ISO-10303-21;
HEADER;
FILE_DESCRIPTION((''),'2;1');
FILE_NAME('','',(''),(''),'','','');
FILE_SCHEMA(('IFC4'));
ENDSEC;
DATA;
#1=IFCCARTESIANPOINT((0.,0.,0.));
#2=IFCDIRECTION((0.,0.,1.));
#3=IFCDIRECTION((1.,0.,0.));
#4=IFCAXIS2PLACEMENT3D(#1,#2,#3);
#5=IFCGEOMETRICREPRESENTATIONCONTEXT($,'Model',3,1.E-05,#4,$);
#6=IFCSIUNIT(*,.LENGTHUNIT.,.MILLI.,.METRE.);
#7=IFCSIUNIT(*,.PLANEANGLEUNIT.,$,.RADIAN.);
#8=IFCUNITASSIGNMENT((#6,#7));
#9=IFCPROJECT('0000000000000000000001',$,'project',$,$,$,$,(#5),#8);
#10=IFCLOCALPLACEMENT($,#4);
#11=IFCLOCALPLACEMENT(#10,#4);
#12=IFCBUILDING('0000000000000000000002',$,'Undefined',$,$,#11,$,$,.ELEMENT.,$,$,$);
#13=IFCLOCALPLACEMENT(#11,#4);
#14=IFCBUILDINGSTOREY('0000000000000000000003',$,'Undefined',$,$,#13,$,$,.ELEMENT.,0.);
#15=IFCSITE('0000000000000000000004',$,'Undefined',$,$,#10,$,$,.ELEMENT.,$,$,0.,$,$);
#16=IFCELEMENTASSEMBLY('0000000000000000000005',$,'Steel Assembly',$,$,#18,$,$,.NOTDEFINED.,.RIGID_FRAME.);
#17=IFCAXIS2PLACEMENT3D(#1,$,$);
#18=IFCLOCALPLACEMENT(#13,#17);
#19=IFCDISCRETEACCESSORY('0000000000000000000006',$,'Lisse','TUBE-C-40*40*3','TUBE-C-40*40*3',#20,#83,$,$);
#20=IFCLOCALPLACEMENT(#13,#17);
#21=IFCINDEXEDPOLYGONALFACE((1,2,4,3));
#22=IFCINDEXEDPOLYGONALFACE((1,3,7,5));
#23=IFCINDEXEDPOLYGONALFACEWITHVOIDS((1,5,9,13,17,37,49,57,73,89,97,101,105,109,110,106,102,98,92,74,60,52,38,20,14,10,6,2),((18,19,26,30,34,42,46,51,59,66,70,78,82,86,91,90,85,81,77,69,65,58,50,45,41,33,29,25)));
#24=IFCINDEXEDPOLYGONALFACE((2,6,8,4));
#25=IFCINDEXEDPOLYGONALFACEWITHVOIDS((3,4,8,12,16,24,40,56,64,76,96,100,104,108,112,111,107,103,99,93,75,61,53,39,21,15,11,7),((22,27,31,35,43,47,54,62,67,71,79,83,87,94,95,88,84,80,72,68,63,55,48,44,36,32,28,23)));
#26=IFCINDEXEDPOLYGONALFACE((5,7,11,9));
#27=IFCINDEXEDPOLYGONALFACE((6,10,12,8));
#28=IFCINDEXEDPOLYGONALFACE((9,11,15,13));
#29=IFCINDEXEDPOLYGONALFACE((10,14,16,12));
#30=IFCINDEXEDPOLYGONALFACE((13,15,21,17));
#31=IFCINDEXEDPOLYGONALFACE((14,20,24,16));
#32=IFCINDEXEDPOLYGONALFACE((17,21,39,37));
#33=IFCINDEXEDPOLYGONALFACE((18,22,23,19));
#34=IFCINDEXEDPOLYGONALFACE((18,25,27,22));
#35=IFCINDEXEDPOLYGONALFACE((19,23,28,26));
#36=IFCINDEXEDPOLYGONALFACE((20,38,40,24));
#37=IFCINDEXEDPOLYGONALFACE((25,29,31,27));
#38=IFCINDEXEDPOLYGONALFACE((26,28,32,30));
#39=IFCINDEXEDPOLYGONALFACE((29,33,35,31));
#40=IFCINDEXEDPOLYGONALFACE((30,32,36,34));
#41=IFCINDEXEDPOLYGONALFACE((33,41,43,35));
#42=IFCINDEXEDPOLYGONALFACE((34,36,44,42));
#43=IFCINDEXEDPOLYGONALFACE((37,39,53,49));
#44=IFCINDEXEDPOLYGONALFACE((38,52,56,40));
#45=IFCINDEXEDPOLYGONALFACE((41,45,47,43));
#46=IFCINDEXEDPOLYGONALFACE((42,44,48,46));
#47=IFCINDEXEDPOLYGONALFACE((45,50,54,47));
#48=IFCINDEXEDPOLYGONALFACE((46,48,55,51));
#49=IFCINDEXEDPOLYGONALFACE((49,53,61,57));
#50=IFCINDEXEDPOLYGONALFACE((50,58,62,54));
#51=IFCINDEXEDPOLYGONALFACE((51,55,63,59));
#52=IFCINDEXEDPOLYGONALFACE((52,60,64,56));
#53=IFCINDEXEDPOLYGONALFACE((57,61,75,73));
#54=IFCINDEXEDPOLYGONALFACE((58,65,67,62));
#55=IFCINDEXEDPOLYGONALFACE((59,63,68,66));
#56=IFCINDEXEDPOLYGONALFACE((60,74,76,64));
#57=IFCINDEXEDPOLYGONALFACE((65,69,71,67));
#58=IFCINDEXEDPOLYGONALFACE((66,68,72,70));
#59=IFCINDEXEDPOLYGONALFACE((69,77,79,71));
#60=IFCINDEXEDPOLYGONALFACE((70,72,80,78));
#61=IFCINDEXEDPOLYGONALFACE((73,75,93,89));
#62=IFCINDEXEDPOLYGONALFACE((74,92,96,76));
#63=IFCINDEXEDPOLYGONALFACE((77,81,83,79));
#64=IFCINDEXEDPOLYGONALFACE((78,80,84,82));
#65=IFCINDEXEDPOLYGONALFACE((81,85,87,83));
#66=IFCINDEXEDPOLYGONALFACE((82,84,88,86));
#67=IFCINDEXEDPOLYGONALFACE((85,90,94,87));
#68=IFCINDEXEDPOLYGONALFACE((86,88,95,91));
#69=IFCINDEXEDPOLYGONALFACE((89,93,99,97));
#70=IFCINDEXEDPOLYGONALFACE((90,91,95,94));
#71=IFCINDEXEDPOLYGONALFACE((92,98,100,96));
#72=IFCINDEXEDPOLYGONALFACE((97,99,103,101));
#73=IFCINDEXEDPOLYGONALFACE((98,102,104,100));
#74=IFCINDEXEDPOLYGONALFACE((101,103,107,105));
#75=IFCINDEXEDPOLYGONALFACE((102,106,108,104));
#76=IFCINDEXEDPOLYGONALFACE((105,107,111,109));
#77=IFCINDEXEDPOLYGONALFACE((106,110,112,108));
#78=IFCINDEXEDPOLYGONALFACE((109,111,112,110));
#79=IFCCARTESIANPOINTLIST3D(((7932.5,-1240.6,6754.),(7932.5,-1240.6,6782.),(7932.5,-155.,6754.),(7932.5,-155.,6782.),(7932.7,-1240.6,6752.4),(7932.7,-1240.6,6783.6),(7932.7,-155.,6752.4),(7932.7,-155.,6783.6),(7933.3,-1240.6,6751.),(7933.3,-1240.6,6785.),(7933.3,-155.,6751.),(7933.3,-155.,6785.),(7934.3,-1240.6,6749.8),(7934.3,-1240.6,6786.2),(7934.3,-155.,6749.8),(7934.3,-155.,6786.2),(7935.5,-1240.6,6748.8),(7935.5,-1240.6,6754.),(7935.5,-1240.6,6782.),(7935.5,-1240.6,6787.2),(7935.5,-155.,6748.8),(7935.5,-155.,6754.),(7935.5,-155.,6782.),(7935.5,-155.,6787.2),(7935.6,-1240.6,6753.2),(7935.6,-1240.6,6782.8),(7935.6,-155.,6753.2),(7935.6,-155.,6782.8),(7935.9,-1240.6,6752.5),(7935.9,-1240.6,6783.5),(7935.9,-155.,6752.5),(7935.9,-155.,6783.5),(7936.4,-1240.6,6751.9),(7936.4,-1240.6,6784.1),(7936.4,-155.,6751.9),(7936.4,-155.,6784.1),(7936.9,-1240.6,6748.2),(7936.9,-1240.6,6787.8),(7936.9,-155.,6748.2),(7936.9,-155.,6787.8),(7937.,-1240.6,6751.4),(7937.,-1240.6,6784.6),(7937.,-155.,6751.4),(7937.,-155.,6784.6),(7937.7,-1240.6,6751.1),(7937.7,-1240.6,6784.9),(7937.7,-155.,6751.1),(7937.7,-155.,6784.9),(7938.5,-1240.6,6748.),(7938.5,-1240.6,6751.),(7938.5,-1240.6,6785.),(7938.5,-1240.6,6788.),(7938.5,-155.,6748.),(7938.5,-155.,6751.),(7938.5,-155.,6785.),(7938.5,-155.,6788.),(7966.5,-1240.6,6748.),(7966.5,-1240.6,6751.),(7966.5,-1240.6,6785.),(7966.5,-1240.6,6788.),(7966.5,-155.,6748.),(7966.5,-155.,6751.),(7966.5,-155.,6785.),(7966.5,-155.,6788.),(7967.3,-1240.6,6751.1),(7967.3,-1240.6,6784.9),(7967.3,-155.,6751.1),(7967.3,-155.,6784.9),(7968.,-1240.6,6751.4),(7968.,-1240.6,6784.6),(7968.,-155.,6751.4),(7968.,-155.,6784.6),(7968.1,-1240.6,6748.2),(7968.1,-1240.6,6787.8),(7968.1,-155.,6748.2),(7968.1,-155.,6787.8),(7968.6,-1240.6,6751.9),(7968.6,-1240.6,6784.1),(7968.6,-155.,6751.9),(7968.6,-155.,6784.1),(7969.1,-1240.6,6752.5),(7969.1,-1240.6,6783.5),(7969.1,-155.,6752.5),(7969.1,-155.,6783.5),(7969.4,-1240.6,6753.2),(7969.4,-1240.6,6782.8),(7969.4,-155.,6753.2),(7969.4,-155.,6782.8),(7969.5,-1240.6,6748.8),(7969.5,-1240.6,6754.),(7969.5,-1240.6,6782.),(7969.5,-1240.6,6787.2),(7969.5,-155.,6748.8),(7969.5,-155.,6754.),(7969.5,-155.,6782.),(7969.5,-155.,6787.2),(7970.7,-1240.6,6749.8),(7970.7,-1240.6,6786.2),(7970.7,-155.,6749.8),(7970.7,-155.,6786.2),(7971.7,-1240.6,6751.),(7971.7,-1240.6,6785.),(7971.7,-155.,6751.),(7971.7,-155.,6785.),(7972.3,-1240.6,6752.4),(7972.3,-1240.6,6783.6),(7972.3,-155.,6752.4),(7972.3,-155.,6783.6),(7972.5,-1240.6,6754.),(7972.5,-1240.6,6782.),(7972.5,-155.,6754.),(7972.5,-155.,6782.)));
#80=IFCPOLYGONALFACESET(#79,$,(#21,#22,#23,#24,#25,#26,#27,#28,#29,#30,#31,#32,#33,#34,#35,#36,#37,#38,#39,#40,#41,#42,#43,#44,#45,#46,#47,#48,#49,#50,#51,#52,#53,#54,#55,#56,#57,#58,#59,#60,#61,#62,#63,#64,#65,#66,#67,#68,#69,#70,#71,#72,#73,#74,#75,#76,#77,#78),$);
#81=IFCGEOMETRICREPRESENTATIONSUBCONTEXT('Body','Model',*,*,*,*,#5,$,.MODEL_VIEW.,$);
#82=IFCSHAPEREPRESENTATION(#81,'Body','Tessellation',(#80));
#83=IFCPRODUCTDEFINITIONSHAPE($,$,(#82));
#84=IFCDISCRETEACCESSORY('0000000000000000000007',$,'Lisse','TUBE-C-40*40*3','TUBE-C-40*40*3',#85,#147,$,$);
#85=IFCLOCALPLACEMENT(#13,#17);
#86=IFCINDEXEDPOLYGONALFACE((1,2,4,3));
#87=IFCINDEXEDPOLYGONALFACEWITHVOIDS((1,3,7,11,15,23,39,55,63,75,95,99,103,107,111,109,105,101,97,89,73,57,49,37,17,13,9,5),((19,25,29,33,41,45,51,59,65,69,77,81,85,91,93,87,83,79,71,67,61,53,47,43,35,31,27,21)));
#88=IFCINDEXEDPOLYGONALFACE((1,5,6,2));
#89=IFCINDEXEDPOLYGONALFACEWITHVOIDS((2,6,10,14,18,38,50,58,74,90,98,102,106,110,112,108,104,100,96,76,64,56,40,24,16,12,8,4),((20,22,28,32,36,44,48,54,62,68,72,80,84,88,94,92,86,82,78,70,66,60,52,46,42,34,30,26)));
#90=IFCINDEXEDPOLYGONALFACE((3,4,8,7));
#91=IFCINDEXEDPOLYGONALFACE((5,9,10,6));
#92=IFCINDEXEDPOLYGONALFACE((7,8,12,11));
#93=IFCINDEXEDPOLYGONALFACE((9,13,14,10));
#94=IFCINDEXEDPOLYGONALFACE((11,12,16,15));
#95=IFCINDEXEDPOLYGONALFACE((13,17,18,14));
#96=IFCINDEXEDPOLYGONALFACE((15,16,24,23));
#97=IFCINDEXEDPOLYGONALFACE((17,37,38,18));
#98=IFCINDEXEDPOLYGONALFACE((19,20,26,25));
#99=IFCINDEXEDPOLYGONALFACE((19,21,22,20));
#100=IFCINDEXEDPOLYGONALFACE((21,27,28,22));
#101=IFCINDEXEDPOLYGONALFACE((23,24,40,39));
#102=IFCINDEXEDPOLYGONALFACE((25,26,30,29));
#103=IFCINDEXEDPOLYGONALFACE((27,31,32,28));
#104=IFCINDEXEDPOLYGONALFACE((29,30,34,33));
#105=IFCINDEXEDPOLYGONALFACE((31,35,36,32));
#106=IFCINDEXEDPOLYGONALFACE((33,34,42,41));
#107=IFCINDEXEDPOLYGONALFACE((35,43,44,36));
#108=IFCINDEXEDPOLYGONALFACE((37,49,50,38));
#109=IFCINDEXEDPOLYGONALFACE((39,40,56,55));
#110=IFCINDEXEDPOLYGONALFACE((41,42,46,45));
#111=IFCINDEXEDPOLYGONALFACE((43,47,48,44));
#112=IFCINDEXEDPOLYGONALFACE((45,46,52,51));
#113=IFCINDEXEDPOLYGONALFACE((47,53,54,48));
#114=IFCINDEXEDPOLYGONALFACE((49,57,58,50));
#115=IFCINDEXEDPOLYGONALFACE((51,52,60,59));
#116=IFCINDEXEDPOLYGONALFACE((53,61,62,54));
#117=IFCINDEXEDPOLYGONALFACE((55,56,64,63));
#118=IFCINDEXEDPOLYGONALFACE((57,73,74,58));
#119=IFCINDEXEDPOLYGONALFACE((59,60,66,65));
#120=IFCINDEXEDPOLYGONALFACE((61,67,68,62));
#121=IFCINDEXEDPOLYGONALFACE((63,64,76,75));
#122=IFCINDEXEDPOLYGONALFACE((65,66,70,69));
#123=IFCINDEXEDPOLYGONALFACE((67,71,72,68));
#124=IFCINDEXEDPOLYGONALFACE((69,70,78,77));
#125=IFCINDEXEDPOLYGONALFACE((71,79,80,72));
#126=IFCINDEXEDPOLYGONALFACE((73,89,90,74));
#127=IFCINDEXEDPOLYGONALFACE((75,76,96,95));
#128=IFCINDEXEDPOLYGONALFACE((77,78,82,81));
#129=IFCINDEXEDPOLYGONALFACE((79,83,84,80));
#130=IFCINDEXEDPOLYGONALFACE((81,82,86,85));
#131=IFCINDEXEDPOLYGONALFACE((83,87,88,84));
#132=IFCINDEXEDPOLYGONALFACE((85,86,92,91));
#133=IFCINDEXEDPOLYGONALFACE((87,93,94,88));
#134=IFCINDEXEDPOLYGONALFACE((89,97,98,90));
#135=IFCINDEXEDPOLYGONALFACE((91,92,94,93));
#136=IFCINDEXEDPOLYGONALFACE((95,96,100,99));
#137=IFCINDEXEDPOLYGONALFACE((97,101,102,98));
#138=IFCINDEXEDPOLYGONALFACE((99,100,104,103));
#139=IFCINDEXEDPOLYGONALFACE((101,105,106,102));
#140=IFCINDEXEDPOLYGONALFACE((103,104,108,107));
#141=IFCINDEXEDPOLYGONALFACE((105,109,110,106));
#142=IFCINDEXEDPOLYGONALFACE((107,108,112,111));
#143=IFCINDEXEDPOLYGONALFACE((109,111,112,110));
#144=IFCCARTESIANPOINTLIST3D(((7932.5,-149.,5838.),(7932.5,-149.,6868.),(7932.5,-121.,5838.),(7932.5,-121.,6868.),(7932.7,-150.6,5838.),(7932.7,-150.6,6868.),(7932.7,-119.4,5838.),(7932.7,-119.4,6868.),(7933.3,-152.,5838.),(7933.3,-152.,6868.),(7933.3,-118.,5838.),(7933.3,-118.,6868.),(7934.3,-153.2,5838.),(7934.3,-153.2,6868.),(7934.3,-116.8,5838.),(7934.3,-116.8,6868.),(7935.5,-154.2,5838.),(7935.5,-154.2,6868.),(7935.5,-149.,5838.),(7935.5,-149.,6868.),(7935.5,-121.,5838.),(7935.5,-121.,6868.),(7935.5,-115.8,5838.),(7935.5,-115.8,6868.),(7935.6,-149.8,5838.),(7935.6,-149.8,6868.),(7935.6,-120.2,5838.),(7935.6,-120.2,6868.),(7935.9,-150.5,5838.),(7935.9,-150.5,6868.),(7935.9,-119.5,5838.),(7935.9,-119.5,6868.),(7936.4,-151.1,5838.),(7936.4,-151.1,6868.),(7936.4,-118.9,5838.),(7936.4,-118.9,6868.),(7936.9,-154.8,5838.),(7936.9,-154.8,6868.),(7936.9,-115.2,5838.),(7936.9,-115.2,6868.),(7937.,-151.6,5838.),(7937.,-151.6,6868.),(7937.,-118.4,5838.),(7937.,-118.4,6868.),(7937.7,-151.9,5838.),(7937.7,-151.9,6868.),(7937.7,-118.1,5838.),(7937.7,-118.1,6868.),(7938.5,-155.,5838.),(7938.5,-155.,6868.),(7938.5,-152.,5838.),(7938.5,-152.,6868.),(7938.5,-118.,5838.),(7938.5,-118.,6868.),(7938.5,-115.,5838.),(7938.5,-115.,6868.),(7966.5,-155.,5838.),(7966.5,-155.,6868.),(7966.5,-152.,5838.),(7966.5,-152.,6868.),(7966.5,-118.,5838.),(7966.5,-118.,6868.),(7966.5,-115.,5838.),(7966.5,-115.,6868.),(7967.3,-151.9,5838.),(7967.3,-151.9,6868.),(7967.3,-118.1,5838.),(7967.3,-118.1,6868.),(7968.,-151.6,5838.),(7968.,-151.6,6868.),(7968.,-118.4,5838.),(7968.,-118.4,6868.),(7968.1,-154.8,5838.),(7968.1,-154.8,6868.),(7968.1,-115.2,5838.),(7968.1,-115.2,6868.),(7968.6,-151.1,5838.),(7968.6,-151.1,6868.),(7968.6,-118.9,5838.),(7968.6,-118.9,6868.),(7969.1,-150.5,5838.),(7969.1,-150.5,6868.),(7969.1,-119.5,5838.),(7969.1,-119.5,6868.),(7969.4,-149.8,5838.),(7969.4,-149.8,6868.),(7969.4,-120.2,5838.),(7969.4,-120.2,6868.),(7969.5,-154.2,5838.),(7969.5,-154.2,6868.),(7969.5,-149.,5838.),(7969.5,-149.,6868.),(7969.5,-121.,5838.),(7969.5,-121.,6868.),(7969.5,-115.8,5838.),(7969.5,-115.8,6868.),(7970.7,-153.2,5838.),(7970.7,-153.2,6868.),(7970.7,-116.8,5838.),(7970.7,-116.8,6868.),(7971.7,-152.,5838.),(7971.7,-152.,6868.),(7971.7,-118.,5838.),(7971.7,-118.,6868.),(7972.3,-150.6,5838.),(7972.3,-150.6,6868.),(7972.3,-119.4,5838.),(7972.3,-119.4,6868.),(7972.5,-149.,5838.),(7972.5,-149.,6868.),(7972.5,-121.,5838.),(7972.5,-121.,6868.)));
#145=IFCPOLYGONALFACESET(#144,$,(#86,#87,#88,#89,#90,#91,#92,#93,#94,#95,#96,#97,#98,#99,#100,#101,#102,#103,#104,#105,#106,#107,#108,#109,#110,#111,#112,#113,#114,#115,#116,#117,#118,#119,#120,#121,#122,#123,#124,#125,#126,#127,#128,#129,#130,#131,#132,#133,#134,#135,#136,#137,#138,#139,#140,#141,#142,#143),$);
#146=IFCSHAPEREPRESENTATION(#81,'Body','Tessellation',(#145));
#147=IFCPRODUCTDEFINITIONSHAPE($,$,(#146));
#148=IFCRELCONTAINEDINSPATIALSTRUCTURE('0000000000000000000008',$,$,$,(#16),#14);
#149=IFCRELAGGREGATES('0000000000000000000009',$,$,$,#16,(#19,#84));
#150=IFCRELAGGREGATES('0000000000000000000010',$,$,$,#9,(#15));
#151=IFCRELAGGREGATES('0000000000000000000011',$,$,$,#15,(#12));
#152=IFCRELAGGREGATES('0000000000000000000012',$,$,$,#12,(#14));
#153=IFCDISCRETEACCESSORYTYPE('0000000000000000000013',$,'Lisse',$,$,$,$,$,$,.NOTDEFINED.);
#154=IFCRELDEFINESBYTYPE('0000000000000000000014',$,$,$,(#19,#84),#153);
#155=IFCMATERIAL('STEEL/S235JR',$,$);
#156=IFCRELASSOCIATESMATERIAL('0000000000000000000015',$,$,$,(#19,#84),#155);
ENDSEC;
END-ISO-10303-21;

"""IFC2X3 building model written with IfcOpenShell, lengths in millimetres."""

from ifc_helpers import new_model, si_unit, frame, origin_with_axes, origin_2d_with_axis, place, context, subcontext, project, spatial, hollow_rectangle, extrude, material, type_object, element, aggregate, save


model = new_model("IFC2X3")

# Units and contexts
model_context = context("Model", 3, precision=1e-05, world=origin_with_axes())
body_context = subcontext(model_context, "Body", "Model", "MODEL_VIEW")
ifc_project = project(units=[si_unit("LENGTHUNIT", "METRE", prefix="MILLI"), si_unit("PLANEANGLEUNIT", "RADIAN")], contexts=[model_context])

# Site, building, storey
site_placement = place(None, origin_with_axes())
site = spatial("IfcSite", under=ifc_project, at=site_placement, Name="Undefined", CompositionType="ELEMENT", RefElevation=0.0)
building_placement = place(site_placement, origin_with_axes())
building = spatial("IfcBuilding", under=site, at=building_placement, Name="Undefined", CompositionType="ELEMENT")
storey_placement = place(building_placement, origin_with_axes())
storey = spatial("IfcBuildingStorey", under=building, at=storey_placement, Name="Undefined", CompositionType="ELEMENT", Elevation=0.0)

# Element assembly
assembly_1_placement = place(storey_placement, origin_with_axes())
assembly_1 = element("IfcElementAssembly", 1, at=assembly_1_placement, inside=storey, Name="Steel Assembly", AssemblyPlace="NOTDEFINED", PredefinedType="RIGID_FRAME")
ifc_material_1 = material(Name="STEEL/S235JR")

# Discrete accessories
discrete_accessory_type_1 = type_object("IfcDiscreteAccessoryType", Name="Lisse")
discrete_accessory_1_placement = place(assembly_1_placement, frame((7952.5, -155.0, 6768.0), z_axis=(-1.0, 0.0, 0.0), x_axis=(0.0, -1.0, 0.0)))
discrete_accessory_1 = element("IfcDiscreteAccessory", 2, at=discrete_accessory_1_placement, type_object=discrete_accessory_type_1, material=ifc_material_1, Name="Lisse", Description="TUBE-C-40*40*3", ObjectType="TUBE-C-40*40*3", context=body_context, shape_type="SweptSolid", body=[
    extrude(hollow_rectangle(XDim=40.0, YDim=40.0, WallThickness=3.0, InnerFilletRadius=3.0, OuterFilletRadius=6.0, at=origin_2d_with_axis()), frame((1085.6, 0.0, 0.0), z_axis=(-1.0, 0.0, 0.0), x_axis=(0.0, -1.0, 0.0)), (0.0, 0.0, 1.0), 1085.6),
])
discrete_accessory_2_placement = place(assembly_1_placement, frame((7952.5, -135.0, 6868.0), z_axis=(0.0, 1.0, 0.0), x_axis=(0.0, 0.0, -1.0)))
discrete_accessory_2 = element("IfcDiscreteAccessory", 3, at=discrete_accessory_2_placement, type_object=discrete_accessory_type_1, material=ifc_material_1, Name="Lisse", Description="TUBE-C-40*40*3", ObjectType="TUBE-C-40*40*3", context=body_context, shape_type="SweptSolid", body=[
    extrude(hollow_rectangle(XDim=40.0, YDim=40.0, WallThickness=3.0, InnerFilletRadius=3.0, OuterFilletRadius=6.0, at=origin_2d_with_axis()), frame((1030.0, 0.0, 0.0), z_axis=(-1.0, 0.0, 0.0), x_axis=(0.0, -1.0, 0.0)), (0.0, 0.0, 1.0), 1030.0),
])
aggregate(assembly_1, [discrete_accessory_1, discrete_accessory_2])

save(model, "model.ifc")
